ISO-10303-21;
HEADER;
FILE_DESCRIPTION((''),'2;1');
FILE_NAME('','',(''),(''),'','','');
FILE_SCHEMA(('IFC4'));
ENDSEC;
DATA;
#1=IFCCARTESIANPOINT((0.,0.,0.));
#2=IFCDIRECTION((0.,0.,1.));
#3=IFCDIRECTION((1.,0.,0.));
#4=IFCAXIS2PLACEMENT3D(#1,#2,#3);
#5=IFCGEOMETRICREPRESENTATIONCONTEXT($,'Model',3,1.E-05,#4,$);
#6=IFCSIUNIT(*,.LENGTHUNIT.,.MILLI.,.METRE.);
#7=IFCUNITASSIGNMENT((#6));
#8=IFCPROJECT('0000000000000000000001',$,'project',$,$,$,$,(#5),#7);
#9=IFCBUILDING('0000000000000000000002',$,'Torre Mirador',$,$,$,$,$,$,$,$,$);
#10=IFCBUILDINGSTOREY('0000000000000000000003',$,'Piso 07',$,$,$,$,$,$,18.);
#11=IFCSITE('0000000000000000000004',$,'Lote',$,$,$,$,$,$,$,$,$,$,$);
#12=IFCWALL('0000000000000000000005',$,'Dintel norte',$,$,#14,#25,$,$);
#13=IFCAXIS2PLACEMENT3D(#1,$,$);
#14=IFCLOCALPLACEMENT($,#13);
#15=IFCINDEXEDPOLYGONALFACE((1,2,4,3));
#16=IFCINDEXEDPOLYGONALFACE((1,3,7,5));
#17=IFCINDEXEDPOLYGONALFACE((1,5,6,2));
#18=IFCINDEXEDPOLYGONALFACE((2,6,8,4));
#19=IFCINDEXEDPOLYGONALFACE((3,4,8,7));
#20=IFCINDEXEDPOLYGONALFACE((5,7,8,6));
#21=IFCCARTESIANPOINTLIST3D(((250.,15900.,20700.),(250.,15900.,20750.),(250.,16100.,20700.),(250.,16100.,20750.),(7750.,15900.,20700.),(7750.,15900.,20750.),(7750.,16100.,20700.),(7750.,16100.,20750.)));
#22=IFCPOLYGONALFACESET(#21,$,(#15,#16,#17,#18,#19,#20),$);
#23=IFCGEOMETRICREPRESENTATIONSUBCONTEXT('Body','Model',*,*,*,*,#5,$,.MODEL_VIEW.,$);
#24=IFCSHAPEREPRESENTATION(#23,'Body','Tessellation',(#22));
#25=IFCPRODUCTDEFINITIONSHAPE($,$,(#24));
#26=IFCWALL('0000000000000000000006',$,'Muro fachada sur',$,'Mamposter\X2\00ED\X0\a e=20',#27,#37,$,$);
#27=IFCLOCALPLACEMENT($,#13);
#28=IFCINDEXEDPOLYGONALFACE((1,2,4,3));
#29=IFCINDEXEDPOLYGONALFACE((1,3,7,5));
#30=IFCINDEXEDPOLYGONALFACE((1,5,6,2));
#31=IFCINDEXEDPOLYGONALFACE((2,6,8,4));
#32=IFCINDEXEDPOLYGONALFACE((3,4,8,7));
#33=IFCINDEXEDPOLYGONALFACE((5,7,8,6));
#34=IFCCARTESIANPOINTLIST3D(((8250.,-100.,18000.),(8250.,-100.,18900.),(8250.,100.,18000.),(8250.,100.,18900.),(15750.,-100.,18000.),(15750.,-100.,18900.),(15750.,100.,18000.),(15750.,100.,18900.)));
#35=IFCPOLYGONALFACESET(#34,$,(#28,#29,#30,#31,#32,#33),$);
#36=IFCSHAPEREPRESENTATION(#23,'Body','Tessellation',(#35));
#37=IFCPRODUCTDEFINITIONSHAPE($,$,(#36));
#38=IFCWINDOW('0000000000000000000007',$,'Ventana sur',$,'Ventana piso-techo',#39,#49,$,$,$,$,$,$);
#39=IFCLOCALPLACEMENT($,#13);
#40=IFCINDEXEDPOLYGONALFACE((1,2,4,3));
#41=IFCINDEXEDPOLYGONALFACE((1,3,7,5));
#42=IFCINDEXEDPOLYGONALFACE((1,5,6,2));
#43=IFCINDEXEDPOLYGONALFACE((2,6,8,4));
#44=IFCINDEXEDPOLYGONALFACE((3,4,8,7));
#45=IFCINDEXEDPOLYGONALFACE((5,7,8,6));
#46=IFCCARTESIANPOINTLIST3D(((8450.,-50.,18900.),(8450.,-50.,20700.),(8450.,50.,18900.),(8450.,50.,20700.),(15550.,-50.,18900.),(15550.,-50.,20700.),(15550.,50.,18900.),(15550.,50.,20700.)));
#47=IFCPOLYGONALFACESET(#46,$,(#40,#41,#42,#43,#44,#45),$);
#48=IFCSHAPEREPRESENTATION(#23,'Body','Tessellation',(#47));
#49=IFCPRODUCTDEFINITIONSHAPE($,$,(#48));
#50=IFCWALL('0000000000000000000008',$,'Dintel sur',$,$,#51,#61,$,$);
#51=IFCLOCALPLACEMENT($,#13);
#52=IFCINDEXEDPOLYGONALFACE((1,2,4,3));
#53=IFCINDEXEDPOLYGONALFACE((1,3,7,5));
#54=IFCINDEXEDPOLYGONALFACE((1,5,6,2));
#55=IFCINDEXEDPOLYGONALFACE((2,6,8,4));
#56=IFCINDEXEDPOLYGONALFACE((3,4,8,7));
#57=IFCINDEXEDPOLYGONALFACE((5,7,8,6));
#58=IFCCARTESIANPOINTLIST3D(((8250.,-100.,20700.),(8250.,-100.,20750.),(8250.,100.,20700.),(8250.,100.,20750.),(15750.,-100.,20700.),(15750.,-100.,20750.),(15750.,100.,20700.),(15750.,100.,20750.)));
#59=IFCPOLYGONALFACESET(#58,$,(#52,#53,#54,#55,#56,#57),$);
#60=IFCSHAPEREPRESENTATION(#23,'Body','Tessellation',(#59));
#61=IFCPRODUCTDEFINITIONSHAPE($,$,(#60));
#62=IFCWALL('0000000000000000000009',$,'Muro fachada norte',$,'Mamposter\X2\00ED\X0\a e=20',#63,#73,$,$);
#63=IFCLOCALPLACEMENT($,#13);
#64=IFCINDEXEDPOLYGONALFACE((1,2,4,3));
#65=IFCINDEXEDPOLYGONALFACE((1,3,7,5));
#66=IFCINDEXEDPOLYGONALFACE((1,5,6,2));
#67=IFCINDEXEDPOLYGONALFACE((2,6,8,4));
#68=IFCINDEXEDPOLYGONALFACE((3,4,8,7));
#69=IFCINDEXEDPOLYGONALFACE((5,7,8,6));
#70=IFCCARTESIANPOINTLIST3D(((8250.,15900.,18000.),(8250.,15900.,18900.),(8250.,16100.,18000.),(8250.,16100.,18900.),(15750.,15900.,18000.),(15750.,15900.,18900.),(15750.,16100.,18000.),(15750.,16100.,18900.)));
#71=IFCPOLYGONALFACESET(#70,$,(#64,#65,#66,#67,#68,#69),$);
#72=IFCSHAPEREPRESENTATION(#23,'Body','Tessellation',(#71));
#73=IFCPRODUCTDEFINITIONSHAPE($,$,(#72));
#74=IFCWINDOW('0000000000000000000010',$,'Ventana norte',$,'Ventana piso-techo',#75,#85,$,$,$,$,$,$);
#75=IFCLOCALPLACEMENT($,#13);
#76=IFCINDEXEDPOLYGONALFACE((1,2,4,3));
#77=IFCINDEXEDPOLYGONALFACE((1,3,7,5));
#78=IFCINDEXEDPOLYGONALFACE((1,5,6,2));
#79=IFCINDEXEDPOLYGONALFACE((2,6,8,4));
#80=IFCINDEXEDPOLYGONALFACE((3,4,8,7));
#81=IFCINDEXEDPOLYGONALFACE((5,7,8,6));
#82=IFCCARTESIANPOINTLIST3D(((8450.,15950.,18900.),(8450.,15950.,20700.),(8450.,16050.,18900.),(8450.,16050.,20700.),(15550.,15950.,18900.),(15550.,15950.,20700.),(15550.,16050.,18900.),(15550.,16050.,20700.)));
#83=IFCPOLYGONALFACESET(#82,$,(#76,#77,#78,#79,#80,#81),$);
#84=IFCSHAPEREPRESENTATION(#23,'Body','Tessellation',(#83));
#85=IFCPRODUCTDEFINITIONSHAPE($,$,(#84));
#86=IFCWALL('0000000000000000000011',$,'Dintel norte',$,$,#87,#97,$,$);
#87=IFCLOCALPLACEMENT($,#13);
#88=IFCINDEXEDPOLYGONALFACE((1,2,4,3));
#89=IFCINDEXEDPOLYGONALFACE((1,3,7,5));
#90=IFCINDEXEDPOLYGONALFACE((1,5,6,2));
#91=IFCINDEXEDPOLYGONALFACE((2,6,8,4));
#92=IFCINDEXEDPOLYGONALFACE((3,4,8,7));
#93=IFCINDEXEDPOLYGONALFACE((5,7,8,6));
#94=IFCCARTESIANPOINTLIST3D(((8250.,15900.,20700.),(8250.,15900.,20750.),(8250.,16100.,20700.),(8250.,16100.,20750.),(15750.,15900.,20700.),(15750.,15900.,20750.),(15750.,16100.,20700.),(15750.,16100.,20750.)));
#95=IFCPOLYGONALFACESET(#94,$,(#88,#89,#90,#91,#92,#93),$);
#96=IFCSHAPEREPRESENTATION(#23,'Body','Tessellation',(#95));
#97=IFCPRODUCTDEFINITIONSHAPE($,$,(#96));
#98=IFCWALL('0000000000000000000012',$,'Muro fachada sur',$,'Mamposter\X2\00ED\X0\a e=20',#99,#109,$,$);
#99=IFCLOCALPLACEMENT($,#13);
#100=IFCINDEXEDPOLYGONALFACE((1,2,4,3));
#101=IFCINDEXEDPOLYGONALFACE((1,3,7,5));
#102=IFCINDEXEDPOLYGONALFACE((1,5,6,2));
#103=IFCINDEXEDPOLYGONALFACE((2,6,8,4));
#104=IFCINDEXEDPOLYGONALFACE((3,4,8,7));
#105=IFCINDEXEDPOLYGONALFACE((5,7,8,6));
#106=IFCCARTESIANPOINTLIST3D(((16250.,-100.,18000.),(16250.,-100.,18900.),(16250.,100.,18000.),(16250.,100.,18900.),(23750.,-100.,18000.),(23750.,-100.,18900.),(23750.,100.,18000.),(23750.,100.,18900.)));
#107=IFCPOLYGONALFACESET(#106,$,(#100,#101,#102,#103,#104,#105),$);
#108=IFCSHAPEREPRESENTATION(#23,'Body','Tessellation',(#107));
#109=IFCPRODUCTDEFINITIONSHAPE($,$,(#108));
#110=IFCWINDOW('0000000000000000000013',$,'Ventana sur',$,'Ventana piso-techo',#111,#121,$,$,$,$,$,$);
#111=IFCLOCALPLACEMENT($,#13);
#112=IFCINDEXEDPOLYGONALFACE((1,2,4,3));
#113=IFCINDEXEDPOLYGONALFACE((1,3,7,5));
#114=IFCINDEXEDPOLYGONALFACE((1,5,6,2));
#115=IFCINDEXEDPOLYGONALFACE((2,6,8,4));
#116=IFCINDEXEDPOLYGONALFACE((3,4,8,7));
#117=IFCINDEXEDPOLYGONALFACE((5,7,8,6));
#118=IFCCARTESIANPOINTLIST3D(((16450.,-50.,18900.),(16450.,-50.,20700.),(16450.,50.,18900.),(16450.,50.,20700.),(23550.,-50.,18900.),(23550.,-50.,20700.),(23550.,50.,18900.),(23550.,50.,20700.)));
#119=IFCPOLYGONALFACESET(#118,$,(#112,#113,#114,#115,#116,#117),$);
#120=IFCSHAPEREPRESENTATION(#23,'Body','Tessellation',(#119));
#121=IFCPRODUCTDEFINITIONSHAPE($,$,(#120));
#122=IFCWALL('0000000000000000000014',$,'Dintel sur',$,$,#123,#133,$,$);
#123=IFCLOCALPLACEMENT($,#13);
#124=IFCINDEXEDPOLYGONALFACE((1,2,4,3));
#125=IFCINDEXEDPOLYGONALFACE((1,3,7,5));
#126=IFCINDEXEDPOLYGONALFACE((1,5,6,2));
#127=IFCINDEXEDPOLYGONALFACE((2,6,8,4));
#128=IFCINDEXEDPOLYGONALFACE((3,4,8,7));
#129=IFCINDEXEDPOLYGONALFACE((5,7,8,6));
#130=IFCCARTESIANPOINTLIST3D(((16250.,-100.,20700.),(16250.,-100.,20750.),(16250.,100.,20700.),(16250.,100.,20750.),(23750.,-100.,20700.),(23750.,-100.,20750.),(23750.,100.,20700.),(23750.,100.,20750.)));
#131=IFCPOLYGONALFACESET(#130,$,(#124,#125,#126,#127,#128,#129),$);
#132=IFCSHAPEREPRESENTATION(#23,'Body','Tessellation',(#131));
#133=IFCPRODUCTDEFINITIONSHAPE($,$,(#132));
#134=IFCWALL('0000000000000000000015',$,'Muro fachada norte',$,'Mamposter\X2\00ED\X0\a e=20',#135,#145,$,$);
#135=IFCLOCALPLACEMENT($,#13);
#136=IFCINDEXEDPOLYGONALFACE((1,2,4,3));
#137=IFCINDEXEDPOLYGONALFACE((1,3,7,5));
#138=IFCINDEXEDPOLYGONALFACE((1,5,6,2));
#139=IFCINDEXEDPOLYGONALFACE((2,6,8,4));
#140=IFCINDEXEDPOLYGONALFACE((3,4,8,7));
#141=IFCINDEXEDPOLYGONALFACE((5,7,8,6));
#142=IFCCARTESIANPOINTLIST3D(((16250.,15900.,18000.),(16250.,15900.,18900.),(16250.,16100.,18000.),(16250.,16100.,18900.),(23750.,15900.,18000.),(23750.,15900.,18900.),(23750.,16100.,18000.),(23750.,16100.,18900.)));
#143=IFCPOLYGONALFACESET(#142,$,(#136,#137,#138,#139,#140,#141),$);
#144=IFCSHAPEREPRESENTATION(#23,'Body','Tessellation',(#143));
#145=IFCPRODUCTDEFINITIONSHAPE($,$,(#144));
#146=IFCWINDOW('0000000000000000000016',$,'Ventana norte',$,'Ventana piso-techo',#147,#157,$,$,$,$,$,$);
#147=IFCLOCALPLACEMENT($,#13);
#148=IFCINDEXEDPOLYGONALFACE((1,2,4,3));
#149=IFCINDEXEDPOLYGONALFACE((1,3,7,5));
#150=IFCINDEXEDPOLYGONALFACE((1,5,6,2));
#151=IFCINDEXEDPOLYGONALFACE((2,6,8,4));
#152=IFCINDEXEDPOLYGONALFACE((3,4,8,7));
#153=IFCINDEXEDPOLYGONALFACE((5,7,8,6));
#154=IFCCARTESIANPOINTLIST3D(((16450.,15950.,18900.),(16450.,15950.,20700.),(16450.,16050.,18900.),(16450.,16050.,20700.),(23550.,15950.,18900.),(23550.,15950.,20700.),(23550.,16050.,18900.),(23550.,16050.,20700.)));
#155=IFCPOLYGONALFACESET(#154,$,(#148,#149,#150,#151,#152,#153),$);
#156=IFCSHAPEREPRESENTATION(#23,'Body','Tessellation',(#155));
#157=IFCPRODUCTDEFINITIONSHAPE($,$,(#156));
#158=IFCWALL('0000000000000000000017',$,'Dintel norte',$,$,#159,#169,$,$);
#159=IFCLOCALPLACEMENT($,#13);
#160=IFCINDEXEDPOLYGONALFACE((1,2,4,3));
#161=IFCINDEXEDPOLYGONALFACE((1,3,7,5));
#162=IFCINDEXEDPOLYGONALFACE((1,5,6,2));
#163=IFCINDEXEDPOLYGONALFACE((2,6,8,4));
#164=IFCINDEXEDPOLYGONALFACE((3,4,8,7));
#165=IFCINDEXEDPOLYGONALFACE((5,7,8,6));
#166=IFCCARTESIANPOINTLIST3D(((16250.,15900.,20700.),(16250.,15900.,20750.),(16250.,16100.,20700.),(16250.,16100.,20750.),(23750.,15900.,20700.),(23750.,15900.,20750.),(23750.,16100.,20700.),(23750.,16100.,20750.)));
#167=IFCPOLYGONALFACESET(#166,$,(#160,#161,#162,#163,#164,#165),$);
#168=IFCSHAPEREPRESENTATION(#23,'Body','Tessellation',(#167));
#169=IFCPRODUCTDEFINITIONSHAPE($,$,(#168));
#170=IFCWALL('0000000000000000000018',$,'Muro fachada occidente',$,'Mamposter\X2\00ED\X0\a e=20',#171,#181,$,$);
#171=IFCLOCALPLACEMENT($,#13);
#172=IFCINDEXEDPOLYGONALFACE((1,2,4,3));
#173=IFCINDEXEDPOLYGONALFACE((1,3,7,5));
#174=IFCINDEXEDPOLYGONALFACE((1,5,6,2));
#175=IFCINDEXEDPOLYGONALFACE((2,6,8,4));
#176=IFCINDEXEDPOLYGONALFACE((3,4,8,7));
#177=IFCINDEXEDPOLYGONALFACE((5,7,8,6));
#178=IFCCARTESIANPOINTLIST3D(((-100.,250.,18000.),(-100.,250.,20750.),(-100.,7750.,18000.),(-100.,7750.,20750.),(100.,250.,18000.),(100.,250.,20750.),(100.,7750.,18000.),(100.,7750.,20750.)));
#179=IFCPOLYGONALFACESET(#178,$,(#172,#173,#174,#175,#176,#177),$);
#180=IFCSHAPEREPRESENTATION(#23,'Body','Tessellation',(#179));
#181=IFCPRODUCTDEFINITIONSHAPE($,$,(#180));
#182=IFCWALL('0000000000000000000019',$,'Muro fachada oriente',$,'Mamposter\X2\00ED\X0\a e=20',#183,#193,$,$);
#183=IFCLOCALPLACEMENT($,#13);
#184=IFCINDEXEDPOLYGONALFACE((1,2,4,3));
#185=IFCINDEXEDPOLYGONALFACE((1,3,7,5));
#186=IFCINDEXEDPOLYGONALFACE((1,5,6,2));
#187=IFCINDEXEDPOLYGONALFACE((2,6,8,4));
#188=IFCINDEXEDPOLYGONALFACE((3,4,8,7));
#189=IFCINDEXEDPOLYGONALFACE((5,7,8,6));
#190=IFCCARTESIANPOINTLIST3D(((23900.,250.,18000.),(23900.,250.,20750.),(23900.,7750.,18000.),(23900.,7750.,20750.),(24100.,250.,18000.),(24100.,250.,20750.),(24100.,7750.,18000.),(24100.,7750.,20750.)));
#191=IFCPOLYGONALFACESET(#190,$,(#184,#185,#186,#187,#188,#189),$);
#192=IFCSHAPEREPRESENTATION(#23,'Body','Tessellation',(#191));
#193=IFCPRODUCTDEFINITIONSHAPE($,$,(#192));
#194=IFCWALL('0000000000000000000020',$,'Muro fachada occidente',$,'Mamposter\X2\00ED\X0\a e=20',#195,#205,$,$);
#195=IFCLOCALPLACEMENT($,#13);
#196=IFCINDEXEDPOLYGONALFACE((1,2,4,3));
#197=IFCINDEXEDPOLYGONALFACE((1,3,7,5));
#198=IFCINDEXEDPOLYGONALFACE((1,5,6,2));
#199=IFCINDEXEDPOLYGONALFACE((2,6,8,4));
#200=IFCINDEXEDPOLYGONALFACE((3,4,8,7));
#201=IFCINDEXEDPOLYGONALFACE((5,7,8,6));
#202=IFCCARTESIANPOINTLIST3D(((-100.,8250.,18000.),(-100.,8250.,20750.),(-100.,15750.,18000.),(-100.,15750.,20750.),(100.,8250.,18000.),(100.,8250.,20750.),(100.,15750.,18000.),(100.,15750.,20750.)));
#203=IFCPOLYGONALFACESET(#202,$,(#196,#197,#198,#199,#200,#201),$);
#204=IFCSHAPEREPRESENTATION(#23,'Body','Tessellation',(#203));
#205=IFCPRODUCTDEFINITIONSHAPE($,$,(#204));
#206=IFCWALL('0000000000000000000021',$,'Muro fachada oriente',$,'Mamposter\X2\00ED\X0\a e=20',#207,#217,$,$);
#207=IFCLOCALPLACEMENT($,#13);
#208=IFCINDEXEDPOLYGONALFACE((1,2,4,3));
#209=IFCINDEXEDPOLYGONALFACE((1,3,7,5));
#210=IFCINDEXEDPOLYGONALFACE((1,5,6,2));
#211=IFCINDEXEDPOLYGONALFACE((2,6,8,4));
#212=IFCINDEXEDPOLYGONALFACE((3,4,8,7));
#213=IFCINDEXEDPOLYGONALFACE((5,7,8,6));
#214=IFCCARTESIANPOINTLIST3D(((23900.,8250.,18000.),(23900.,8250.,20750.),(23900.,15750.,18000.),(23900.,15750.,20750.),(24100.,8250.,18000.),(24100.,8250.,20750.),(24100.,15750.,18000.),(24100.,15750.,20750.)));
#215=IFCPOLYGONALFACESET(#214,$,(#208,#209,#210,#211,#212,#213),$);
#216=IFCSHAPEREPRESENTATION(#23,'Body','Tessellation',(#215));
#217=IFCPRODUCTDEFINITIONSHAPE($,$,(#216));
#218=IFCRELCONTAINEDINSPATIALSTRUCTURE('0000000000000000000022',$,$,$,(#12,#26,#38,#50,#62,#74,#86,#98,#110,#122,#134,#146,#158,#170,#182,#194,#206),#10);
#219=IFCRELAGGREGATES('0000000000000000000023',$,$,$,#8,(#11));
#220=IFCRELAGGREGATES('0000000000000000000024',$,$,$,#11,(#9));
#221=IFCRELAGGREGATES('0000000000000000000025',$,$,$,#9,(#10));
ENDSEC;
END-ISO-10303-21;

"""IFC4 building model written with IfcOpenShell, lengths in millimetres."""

from ifc_helpers import new_model, si_unit, frame, origin_with_axes, place, context, subcontext, project, spatial, indexed_curve, outline, extrude, element, save


model = new_model("IFC4")

# Units and contexts
model_context = context("Model", 3, precision=1e-05, world=origin_with_axes())
body_context = subcontext(model_context, "Body", "Model", "MODEL_VIEW")
ifc_project = project(units=[si_unit("LENGTHUNIT", "METRE", prefix="MILLI")], contexts=[model_context])

# Site, building, storey
site = spatial("IfcSite", under=ifc_project, Name="Lote")
building = spatial("IfcBuilding", under=site, Name="Torre Mirador")
storey = spatial("IfcBuildingStorey", under=building, Name="Piso 07", Elevation=18.0)

# Walls
wall_1_placement = place(None, frame((250.0, 15900.0, 20700.0), z_axis=(0.0, 0.0, 1.0), x_axis=(1.0, 0.0, 0.0)))
element("IfcWall", 1, at=wall_1_placement, inside=storey, Name="Dintel norte", context=body_context, shape_type="SweptSolid", body=[
    extrude(outline(indexed_curve([(0.0, 0.0), (0.0, 200.0), (7500.0, 200.0), (7500.0, 0.0), (0.0, 0.0)], self_intersect=False)), origin_with_axes(), (0.0, 0.0, 1.0), 50.0),
])
wall_2_placement = place(None, frame((8250.0, -100.0, 18000.0), z_axis=(0.0, 0.0, 1.0), x_axis=(1.0, 0.0, 0.0)))
element("IfcWall", 2, at=wall_2_placement, inside=storey, Name="Muro fachada sur", ObjectType="Mampostería e=20", context=body_context, shape_type="SweptSolid", body=[
    extrude(outline(indexed_curve([(0.0, 0.0), (0.0, 200.0), (7500.0, 200.0), (7500.0, 0.0), (0.0, 0.0)], self_intersect=False)), origin_with_axes(), (0.0, 0.0, 1.0), 900.0),
])

# Window
window_1_placement = place(None, frame((8450.0, -50.0, 18900.0), z_axis=(0.0, 0.0, 1.0), x_axis=(1.0, 0.0, 0.0)))
element("IfcWindow", 3, at=window_1_placement, inside=storey, Name="Ventana sur", ObjectType="Ventana piso-techo", context=body_context, shape_type="SweptSolid", body=[
    extrude(outline(indexed_curve([(0.0, 0.0), (0.0, 100.0), (7100.0, 100.0), (7100.0, 0.0), (0.0, 0.0)], self_intersect=False)), origin_with_axes(), (0.0, 0.0, 1.0), 1800.0),
])

# Walls
wall_3_placement = place(None, frame((8250.0, -100.0, 20700.0), z_axis=(0.0, 0.0, 1.0), x_axis=(1.0, 0.0, 0.0)))
element("IfcWall", 4, at=wall_3_placement, inside=storey, Name="Dintel sur", context=body_context, shape_type="SweptSolid", body=[
    extrude(outline(indexed_curve([(0.0, 0.0), (0.0, 200.0), (7500.0, 200.0), (7500.0, 0.0), (0.0, 0.0)], self_intersect=False)), origin_with_axes(), (0.0, 0.0, 1.0), 50.0),
])
wall_4_placement = place(None, frame((8250.0, 15900.0, 18000.0), z_axis=(0.0, 0.0, 1.0), x_axis=(1.0, 0.0, 0.0)))
element("IfcWall", 5, at=wall_4_placement, inside=storey, Name="Muro fachada norte", ObjectType="Mampostería e=20", context=body_context, shape_type="SweptSolid", body=[
    extrude(outline(indexed_curve([(0.0, 0.0), (0.0, 200.0), (7500.0, 200.0), (7500.0, 0.0), (0.0, 0.0)], self_intersect=False)), origin_with_axes(), (0.0, 0.0, 1.0), 900.0),
])

# Window
window_2_placement = place(None, frame((8450.0, 15950.0, 18900.0), z_axis=(0.0, 0.0, 1.0), x_axis=(1.0, 0.0, 0.0)))
element("IfcWindow", 6, at=window_2_placement, inside=storey, Name="Ventana norte", ObjectType="Ventana piso-techo", context=body_context, shape_type="SweptSolid", body=[
    extrude(outline(indexed_curve([(0.0, 0.0), (0.0, 100.0), (7100.0, 100.0), (7100.0, 0.0), (0.0, 0.0)], self_intersect=False)), origin_with_axes(), (0.0, 0.0, 1.0), 1800.0),
])

# Walls
wall_5_placement = place(None, frame((8250.0, 15900.0, 20700.0), z_axis=(0.0, 0.0, 1.0), x_axis=(1.0, 0.0, 0.0)))
element("IfcWall", 7, at=wall_5_placement, inside=storey, Name="Dintel norte", context=body_context, shape_type="SweptSolid", body=[
    extrude(outline(indexed_curve([(0.0, 0.0), (0.0, 200.0), (7500.0, 200.0), (7500.0, 0.0), (0.0, 0.0)], self_intersect=False)), origin_with_axes(), (0.0, 0.0, 1.0), 50.0),
])
wall_6_placement = place(None, frame((16250.0, -100.0, 18000.0), z_axis=(0.0, 0.0, 1.0), x_axis=(1.0, 0.0, 0.0)))
element("IfcWall", 8, at=wall_6_placement, inside=storey, Name="Muro fachada sur", ObjectType="Mampostería e=20", context=body_context, shape_type="SweptSolid", body=[
    extrude(outline(indexed_curve([(0.0, 0.0), (0.0, 200.0), (7500.0, 200.0), (7500.0, 0.0), (0.0, 0.0)], self_intersect=False)), origin_with_axes(), (0.0, 0.0, 1.0), 900.0),
])

# Window
window_3_placement = place(None, frame((16450.0, -50.0, 18900.0), z_axis=(0.0, 0.0, 1.0), x_axis=(1.0, 0.0, 0.0)))
element("IfcWindow", 9, at=window_3_placement, inside=storey, Name="Ventana sur", ObjectType="Ventana piso-techo", context=body_context, shape_type="SweptSolid", body=[
    extrude(outline(indexed_curve([(0.0, 0.0), (0.0, 100.0), (7100.0, 100.0), (7100.0, 0.0), (0.0, 0.0)], self_intersect=False)), origin_with_axes(), (0.0, 0.0, 1.0), 1800.0),
])

# Walls
wall_7_placement = place(None, frame((16250.0, -100.0, 20700.0), z_axis=(0.0, 0.0, 1.0), x_axis=(1.0, 0.0, 0.0)))
element("IfcWall", 10, at=wall_7_placement, inside=storey, Name="Dintel sur", context=body_context, shape_type="SweptSolid", body=[
    extrude(outline(indexed_curve([(0.0, 0.0), (0.0, 200.0), (7500.0, 200.0), (7500.0, 0.0), (0.0, 0.0)], self_intersect=False)), origin_with_axes(), (0.0, 0.0, 1.0), 50.0),
])
wall_8_placement = place(None, frame((16250.0, 15900.0, 18000.0), z_axis=(0.0, 0.0, 1.0), x_axis=(1.0, 0.0, 0.0)))
element("IfcWall", 11, at=wall_8_placement, inside=storey, Name="Muro fachada norte", ObjectType="Mampostería e=20", context=body_context, shape_type="SweptSolid", body=[
    extrude(outline(indexed_curve([(0.0, 0.0), (0.0, 200.0), (7500.0, 200.0), (7500.0, 0.0), (0.0, 0.0)], self_intersect=False)), origin_with_axes(), (0.0, 0.0, 1.0), 900.0),
])

# Window
window_4_placement = place(None, frame((16450.0, 15950.0, 18900.0), z_axis=(0.0, 0.0, 1.0), x_axis=(1.0, 0.0, 0.0)))
element("IfcWindow", 12, at=window_4_placement, inside=storey, Name="Ventana norte", ObjectType="Ventana piso-techo", context=body_context, shape_type="SweptSolid", body=[
    extrude(outline(indexed_curve([(0.0, 0.0), (0.0, 100.0), (7100.0, 100.0), (7100.0, 0.0), (0.0, 0.0)], self_intersect=False)), origin_with_axes(), (0.0, 0.0, 1.0), 1800.0),
])

# Walls
wall_9_placement = place(None, frame((16250.0, 15900.0, 20700.0), z_axis=(0.0, 0.0, 1.0), x_axis=(1.0, 0.0, 0.0)))
element("IfcWall", 13, at=wall_9_placement, inside=storey, Name="Dintel norte", context=body_context, shape_type="SweptSolid", body=[
    extrude(outline(indexed_curve([(0.0, 0.0), (0.0, 200.0), (7500.0, 200.0), (7500.0, 0.0), (0.0, 0.0)], self_intersect=False)), origin_with_axes(), (0.0, 0.0, 1.0), 50.0),
])
for number, where, z_axis, x_axis, name in (
    (14, (-100.0, 250.0, 18000.0), (0.0, 0.0, 1.0), (1.0, 0.0, 0.0), "Muro fachada occidente"),
    (15, (23900.0, 250.0, 18000.0), (0.0, 0.0, 1.0), (1.0, 0.0, 0.0), "Muro fachada oriente"),
    (16, (-100.0, 8250.0, 18000.0), (0.0, 0.0, 1.0), (1.0, 0.0, 0.0), "Muro fachada occidente"),
    (17, (23900.0, 8250.0, 18000.0), (0.0, 0.0, 1.0), (1.0, 0.0, 0.0), "Muro fachada oriente"),
):
    element("IfcWall", number, at=place(None, frame(where, z_axis=z_axis, x_axis=x_axis)), inside=storey, Name=name, ObjectType="Mampostería e=20", context=body_context, shape_type="SweptSolid", body=[
        extrude(outline(indexed_curve([(0.0, 0.0), (0.0, 7500.0), (200.0, 7500.0), (200.0, 0.0), (0.0, 0.0)], self_intersect=False)), origin_with_axes(), (0.0, 0.0, 1.0), 2750.0),
    ])

save(model, "model.ifc")
